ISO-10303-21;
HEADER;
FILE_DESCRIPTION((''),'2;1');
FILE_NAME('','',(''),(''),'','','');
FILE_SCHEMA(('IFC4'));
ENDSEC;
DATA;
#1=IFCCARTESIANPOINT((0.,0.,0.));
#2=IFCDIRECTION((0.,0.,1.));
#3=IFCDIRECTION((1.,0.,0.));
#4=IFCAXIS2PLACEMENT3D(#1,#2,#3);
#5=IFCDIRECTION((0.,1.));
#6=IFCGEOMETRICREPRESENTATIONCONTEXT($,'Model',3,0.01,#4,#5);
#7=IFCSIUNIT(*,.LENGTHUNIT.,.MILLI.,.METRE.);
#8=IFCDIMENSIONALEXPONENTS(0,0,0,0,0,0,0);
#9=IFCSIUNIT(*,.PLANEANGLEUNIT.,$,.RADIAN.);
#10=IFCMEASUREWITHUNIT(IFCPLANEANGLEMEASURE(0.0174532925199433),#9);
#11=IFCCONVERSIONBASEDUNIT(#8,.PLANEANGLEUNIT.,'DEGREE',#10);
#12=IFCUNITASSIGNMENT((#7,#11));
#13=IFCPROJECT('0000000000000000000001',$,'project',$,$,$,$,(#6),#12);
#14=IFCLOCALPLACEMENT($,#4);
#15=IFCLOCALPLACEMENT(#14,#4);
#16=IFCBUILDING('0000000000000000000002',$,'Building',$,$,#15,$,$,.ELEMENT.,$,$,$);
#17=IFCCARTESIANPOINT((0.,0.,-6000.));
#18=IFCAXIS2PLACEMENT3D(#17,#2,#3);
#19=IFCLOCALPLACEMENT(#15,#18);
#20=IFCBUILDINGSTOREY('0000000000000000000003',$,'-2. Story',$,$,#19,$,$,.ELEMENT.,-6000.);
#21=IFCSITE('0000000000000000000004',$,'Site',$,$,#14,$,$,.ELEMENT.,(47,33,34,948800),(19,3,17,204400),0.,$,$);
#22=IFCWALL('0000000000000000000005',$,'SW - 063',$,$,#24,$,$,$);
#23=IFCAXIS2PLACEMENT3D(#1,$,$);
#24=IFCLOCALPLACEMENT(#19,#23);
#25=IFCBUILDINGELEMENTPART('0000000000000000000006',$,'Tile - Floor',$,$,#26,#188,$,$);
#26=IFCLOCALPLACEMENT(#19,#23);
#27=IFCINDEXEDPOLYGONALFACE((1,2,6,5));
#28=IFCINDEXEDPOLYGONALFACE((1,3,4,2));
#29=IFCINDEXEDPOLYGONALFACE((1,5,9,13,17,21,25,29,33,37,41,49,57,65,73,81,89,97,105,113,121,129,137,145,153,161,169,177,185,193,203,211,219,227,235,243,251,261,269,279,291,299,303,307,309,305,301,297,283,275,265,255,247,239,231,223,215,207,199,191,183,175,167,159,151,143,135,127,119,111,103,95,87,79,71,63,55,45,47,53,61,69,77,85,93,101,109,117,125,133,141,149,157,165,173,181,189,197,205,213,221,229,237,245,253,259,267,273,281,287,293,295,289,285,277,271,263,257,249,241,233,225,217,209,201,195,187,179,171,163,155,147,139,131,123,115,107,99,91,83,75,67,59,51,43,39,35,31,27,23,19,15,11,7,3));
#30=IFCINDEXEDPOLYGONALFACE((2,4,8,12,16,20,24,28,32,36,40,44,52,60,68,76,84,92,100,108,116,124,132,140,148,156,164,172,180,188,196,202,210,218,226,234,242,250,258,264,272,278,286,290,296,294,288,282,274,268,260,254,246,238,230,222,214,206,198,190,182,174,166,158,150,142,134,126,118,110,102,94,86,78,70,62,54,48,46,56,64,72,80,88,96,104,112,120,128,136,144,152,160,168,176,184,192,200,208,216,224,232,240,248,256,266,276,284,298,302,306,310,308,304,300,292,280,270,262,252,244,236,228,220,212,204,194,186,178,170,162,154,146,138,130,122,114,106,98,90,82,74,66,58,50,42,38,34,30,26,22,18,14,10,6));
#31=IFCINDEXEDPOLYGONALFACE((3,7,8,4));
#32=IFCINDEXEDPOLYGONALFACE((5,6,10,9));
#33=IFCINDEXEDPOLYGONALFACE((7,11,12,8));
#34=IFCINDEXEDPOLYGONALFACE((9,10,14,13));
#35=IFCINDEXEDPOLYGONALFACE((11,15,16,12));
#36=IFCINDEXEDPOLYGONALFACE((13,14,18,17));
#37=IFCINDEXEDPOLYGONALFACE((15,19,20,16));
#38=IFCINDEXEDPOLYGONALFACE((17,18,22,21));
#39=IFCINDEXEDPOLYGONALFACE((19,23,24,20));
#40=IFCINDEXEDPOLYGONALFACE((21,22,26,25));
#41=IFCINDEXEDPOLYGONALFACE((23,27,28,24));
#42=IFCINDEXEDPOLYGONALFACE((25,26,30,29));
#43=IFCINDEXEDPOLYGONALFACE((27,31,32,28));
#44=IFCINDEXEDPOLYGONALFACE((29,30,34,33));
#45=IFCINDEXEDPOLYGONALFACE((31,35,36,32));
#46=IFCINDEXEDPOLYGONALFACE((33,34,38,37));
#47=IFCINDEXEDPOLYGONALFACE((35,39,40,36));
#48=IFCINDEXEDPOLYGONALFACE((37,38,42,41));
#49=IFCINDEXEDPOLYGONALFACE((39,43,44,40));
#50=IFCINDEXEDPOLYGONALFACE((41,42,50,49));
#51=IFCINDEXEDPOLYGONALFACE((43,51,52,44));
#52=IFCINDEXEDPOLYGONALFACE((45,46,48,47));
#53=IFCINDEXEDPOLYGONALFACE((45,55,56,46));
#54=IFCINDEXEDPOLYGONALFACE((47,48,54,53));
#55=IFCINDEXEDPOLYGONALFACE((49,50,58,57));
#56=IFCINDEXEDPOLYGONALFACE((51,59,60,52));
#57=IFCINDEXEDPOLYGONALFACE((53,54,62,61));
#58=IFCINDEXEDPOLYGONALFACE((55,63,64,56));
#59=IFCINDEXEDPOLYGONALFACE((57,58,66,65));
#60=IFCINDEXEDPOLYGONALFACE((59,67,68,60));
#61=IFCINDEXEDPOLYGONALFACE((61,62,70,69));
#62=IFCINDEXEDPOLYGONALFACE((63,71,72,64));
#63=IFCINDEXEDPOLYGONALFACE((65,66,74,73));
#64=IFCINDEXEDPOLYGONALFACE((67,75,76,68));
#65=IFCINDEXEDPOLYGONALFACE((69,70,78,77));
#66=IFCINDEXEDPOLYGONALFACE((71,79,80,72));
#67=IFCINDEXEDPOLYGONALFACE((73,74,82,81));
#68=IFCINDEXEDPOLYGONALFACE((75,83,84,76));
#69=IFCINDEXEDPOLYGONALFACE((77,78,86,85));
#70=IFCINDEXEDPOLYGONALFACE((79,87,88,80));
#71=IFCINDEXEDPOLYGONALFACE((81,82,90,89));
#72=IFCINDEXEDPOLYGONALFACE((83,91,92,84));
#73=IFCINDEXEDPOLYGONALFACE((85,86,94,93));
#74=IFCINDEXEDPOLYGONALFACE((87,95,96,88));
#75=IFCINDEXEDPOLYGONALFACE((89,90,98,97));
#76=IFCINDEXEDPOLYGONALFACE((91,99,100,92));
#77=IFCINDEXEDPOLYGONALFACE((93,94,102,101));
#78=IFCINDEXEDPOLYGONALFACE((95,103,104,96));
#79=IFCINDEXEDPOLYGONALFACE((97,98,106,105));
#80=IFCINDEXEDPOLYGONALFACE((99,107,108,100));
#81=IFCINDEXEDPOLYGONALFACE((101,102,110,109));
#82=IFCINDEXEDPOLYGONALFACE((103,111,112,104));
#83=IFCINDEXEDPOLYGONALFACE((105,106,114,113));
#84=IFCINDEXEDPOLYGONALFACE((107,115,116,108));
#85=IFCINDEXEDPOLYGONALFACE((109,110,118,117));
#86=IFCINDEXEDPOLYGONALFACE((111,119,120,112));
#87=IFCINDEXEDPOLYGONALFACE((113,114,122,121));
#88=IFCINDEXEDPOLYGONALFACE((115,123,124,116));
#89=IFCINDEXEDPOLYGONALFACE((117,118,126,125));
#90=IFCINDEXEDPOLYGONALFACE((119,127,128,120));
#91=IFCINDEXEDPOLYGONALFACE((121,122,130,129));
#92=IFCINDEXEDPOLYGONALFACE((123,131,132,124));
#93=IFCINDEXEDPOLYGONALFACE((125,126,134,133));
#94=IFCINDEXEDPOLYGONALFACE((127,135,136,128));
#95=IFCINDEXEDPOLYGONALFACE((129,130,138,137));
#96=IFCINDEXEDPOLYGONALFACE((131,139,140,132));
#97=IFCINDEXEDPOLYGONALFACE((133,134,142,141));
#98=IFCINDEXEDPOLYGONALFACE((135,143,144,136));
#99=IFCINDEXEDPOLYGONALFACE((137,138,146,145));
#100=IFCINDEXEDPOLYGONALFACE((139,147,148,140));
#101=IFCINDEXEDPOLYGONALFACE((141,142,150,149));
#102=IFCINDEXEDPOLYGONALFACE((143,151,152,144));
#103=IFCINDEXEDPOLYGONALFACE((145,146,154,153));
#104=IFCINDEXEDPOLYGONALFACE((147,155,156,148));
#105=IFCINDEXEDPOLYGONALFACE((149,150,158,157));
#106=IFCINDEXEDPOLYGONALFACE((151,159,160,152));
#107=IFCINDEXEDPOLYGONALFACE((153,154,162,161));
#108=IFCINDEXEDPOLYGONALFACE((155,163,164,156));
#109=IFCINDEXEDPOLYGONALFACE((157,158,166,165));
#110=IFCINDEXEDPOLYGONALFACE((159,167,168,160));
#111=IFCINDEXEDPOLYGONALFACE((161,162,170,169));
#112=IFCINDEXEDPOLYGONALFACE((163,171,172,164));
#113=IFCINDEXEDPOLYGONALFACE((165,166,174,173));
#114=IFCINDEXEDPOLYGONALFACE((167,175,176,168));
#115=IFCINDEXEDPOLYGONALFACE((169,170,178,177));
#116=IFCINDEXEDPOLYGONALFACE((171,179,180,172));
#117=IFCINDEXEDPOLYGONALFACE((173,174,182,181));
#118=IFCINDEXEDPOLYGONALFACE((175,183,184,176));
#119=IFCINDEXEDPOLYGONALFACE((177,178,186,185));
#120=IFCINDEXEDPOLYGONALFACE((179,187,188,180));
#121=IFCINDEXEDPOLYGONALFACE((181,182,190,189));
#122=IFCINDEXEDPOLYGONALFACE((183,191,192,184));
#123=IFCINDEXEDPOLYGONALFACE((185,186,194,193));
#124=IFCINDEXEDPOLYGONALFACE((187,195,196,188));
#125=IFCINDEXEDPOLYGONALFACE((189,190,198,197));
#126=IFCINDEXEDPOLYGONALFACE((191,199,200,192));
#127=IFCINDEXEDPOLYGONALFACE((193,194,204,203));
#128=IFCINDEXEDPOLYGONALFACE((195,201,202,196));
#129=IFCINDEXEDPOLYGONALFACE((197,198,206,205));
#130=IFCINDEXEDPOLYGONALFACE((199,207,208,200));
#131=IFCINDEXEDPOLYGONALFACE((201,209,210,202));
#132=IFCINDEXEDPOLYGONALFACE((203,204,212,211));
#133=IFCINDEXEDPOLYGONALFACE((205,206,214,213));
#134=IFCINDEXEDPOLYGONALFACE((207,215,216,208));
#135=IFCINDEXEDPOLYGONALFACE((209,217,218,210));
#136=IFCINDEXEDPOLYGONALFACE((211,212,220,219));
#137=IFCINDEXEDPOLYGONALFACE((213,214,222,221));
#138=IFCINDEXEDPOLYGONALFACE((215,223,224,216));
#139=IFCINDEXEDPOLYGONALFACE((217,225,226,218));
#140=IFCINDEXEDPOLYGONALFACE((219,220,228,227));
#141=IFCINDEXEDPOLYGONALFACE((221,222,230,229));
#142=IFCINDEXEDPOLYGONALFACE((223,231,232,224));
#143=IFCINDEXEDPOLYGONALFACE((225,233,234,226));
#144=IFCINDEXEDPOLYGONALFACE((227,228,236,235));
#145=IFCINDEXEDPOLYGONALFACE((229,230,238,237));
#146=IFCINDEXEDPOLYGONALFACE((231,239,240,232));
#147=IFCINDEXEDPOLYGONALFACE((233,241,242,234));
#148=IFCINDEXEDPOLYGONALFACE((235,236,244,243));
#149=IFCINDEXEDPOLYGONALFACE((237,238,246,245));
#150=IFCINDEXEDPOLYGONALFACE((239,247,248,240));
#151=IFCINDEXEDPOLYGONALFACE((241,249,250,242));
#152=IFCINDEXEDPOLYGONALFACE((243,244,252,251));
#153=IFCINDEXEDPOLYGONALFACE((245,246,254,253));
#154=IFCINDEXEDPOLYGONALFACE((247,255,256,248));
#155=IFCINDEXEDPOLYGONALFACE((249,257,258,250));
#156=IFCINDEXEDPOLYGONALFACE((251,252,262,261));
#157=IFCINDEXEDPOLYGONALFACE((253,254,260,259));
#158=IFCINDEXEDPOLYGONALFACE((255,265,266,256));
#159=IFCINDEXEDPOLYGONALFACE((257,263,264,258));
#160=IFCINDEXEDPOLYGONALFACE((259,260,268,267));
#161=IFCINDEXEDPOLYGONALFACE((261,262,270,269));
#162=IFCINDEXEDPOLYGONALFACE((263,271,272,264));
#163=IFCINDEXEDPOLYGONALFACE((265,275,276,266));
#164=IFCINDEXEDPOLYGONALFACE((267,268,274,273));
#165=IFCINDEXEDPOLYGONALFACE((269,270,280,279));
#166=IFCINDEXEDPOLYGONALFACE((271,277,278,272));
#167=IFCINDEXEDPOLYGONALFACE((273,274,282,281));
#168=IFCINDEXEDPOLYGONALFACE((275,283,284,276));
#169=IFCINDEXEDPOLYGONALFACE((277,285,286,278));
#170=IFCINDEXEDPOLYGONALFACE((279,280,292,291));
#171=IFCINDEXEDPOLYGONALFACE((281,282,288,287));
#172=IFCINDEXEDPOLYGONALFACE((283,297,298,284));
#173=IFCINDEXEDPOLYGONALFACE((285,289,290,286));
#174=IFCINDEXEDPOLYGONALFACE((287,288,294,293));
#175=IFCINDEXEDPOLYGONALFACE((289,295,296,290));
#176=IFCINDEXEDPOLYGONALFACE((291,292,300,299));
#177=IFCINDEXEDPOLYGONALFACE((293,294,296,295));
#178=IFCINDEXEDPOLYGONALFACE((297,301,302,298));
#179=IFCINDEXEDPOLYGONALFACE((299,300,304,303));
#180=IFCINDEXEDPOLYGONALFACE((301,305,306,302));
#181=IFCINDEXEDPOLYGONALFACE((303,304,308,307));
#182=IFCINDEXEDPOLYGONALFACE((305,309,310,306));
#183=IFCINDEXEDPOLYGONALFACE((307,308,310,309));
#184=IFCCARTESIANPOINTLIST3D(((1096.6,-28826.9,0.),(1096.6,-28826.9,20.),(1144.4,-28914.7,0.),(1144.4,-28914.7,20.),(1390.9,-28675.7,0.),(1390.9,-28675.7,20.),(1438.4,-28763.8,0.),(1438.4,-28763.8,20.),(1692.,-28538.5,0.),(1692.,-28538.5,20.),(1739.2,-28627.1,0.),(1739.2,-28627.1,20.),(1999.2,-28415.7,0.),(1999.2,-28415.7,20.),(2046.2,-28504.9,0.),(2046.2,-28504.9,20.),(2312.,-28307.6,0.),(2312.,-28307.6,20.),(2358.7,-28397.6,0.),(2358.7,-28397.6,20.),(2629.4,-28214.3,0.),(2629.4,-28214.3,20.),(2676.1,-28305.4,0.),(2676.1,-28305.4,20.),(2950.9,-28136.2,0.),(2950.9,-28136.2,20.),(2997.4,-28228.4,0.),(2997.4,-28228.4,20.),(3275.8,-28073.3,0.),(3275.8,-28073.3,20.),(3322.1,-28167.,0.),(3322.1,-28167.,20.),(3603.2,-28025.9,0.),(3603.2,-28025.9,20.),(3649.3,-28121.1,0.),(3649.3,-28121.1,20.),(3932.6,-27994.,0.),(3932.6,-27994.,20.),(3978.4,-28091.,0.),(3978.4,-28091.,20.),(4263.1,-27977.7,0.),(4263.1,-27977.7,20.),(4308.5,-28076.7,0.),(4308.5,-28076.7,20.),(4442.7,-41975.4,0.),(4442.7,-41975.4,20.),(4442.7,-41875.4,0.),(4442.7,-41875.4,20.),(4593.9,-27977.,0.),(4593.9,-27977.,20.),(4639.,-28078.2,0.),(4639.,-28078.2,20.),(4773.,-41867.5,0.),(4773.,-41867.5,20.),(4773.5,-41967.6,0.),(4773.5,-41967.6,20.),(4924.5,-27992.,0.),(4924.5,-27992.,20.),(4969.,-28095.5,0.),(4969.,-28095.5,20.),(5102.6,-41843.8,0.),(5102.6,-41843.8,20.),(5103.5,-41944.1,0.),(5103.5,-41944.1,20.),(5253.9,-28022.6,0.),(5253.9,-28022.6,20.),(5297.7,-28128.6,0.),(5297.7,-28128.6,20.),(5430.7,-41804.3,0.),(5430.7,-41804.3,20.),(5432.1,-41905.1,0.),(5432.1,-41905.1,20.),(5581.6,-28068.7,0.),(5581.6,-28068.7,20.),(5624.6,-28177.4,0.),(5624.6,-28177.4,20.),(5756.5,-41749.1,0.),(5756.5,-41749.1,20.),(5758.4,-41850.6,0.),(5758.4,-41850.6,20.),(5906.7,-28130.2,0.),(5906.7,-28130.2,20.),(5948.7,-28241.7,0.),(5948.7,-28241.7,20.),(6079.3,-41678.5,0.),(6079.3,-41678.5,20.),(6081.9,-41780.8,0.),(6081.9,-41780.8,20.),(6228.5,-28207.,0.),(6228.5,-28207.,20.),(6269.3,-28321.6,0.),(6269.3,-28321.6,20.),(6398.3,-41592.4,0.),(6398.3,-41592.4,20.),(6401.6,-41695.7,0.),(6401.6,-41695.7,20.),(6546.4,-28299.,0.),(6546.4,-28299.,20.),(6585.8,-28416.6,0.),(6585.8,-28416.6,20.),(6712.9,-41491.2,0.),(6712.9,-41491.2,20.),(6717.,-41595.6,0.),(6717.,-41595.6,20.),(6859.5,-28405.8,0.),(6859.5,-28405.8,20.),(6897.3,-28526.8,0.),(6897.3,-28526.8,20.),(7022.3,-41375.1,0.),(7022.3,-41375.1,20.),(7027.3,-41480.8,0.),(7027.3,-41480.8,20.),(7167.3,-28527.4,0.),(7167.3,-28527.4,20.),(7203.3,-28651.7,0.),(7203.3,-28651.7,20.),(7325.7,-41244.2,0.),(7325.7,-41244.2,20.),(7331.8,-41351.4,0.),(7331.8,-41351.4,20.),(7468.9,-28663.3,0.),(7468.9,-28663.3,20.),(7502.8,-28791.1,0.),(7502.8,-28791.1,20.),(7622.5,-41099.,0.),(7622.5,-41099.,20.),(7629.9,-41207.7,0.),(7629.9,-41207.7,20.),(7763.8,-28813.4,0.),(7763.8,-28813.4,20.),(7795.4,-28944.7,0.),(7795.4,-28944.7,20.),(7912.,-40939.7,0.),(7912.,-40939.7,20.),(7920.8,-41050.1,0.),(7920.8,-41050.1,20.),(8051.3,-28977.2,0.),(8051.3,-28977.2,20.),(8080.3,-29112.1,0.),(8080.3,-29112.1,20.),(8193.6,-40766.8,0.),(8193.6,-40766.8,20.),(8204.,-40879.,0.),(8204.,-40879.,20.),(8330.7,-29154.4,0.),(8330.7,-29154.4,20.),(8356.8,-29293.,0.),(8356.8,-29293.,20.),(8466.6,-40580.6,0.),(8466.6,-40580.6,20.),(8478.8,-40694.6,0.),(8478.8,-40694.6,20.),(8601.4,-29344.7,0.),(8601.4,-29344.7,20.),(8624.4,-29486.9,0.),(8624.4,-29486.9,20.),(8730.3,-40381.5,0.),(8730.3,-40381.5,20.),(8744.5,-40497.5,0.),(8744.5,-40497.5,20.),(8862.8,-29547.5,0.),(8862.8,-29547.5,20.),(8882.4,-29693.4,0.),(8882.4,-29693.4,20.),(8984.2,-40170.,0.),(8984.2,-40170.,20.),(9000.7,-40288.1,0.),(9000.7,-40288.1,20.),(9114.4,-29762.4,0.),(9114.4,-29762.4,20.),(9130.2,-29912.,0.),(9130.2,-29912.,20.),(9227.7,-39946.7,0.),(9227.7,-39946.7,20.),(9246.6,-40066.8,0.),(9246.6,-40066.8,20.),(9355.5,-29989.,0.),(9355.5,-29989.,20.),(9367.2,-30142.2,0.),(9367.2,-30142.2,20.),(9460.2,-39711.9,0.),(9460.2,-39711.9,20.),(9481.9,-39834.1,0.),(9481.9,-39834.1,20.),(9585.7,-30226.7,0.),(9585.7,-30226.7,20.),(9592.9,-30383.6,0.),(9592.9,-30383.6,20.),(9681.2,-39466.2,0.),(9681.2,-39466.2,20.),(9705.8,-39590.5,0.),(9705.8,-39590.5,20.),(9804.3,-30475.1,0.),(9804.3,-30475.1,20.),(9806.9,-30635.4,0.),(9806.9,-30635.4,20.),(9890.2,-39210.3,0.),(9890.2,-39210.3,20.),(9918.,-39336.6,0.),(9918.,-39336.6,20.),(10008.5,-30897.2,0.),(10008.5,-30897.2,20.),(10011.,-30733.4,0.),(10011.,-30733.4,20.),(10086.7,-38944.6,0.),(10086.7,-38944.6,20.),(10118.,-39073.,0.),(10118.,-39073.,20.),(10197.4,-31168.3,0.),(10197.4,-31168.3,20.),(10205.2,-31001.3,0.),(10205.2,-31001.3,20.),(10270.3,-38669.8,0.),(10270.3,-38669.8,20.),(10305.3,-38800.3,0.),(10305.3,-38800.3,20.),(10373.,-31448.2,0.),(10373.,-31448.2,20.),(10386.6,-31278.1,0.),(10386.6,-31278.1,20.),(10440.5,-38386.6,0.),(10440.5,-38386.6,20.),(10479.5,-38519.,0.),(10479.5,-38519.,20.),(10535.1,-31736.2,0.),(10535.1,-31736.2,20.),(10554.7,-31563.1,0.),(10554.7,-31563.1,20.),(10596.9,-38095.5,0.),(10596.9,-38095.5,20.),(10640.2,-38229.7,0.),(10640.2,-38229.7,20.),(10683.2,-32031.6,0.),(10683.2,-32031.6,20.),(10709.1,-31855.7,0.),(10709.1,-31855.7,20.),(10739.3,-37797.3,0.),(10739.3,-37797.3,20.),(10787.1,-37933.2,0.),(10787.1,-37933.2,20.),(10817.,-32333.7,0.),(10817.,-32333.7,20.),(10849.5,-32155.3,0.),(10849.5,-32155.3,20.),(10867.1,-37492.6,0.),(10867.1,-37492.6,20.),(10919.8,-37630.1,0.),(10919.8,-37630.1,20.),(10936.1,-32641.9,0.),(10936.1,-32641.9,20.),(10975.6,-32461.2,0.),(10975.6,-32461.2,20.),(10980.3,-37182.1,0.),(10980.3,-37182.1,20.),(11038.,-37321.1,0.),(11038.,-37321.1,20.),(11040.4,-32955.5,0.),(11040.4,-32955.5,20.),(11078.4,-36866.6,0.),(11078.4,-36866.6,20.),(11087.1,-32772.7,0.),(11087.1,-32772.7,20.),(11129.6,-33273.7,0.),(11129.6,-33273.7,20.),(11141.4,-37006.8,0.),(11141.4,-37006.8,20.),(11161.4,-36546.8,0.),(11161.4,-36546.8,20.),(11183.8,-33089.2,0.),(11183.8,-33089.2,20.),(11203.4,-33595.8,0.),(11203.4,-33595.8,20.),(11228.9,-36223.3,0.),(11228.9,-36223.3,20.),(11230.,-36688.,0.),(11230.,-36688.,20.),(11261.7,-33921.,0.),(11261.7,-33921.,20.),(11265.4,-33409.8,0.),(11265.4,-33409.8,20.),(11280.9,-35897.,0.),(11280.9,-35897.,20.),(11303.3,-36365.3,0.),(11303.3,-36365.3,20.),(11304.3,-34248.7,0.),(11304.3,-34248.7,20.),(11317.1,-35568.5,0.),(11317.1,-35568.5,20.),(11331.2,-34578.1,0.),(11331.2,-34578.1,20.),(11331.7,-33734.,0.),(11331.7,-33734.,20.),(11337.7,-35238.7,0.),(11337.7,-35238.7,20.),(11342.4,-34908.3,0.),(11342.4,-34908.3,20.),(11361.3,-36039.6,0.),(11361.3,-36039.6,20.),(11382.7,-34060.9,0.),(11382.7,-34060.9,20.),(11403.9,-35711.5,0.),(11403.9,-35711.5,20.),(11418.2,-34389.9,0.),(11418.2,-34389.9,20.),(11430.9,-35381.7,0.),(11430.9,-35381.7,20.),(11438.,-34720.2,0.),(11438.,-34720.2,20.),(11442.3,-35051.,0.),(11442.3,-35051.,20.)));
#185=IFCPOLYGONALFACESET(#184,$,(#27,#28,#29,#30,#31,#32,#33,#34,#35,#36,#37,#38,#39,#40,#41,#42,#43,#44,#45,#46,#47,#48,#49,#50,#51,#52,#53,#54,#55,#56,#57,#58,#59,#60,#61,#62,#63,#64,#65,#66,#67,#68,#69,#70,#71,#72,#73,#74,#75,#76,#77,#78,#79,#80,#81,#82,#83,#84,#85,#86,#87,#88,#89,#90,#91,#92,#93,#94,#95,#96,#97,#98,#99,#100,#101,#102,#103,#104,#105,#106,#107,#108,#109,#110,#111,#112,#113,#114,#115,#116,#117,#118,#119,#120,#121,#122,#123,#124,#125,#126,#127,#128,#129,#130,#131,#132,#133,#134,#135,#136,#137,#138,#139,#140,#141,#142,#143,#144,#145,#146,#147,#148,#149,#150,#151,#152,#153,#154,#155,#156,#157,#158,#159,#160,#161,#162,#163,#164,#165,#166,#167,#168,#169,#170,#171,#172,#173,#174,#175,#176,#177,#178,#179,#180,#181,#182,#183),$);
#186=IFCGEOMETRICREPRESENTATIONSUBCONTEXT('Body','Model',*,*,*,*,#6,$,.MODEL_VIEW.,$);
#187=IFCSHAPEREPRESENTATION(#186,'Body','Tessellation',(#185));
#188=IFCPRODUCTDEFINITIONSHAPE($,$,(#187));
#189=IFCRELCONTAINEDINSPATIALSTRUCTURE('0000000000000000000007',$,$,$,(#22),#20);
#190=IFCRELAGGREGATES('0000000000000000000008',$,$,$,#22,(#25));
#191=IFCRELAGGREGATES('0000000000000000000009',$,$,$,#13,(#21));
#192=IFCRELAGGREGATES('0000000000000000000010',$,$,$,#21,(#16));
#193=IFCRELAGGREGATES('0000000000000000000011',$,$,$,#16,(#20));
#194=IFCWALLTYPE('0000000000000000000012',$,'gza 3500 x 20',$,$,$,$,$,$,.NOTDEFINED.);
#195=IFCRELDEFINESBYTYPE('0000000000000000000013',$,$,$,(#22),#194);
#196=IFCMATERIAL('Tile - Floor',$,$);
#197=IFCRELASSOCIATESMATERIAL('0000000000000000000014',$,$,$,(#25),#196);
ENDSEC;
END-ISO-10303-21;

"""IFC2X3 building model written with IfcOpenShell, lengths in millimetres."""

from ifc_helpers import new_model, entity, si_unit, converted_unit, direction, frame, origin_with_axes, place, context, subcontext, project, spatial, material, type_object, element, aggregate, save


model = new_model("IFC2X3")

# Units and contexts
model_context = context("Model", 3, precision=0.01, world=origin_with_axes(), true_north=direction((0.0, 1.0)))
body_context = subcontext(model_context, "Body", "Model", "MODEL_VIEW")
ifc_project = project(units=[si_unit("LENGTHUNIT", "METRE", prefix="MILLI"), converted_unit("PLANEANGLEUNIT", "DEGREE", entity("IfcPlaneAngleMeasure", 0.0174532925199433), si_unit("PLANEANGLEUNIT", "RADIAN"), dimensions=[0, 0, 0, 0, 0, 0, 0])], contexts=[model_context])

# Site, building, storey
site_placement = place(None, origin_with_axes())
site = spatial("IfcSite", under=ifc_project, at=site_placement, Name="Site", CompositionType="ELEMENT", RefLatitude=(47, 33, 34, 948800), RefLongitude=(19, 3, 17, 204400), RefElevation=0.0)
building_placement = place(site_placement, origin_with_axes())
building = spatial("IfcBuilding", under=site, at=building_placement, Name="Building", CompositionType="ELEMENT")
storey_placement = place(building_placement, frame((0.0, 0.0, -6000.0), z_axis=(0.0, 0.0, 1.0), x_axis=(1.0, 0.0, 0.0)))
storey = spatial("IfcBuildingStorey", under=building, at=storey_placement, Name="-2. Story", CompositionType="ELEMENT", Elevation=-6000.0)

# Wall, building element part
wall_type_1 = type_object("IfcWallType", Name="gza 3500 x 20", PredefinedType="NOTDEFINED")
ifc_material_1 = material(Name="Tile - Floor")
wall_1_placement = place(storey_placement, frame((4442.7, -41975.4, 0.0), z_axis=(0.0, 0.0, 1.0), x_axis=(1.0, 0.0, 0.0)))
wall_1 = element("IfcWall", 1, at=wall_1_placement, inside=storey, type_object=wall_type_1, Name="SW - 063")
building_element_part_1_placement = place(wall_1_placement, origin_with_axes())
cartesian_point_1 = entity("IfcCartesianPoint", [100.0, 0.0])
building_element_part_1 = element("IfcBuildingElementPart", 2, at=building_element_part_1_placement, material=ifc_material_1, Name="Tile - Floor", context=body_context, shape_type="SweptSolid", body=[
    entity("IfcRevolvedAreaSolid", entity("IfcArbitraryClosedProfileDef", "AREA", None, entity("IfcPolyline", [cartesian_point_1, entity("IfcCartesianPoint", [100.0, 20.0]), entity("IfcCartesianPoint", [0.0, 20.0]), entity("IfcCartesianPoint", [0.0, 0.0]), cartesian_point_1])), entity("IfcAxis2Placement3D", entity("IfcCartesianPoint", [0.0, 0.0, 0.0]), entity("IfcDirection", [1.0, 0.0, 0.0]), entity("IfcDirection", [0.0, 1.0, 0.0])), entity("IfcAxis1Placement", entity("IfcCartesianPoint", [7000.0, 0.0, 0.0]), entity("IfcDirection", [0.0, 1.0, 0.0])), 208.555603),
])
aggregate(wall_1, [building_element_part_1])

save(model, "model.ifc")
